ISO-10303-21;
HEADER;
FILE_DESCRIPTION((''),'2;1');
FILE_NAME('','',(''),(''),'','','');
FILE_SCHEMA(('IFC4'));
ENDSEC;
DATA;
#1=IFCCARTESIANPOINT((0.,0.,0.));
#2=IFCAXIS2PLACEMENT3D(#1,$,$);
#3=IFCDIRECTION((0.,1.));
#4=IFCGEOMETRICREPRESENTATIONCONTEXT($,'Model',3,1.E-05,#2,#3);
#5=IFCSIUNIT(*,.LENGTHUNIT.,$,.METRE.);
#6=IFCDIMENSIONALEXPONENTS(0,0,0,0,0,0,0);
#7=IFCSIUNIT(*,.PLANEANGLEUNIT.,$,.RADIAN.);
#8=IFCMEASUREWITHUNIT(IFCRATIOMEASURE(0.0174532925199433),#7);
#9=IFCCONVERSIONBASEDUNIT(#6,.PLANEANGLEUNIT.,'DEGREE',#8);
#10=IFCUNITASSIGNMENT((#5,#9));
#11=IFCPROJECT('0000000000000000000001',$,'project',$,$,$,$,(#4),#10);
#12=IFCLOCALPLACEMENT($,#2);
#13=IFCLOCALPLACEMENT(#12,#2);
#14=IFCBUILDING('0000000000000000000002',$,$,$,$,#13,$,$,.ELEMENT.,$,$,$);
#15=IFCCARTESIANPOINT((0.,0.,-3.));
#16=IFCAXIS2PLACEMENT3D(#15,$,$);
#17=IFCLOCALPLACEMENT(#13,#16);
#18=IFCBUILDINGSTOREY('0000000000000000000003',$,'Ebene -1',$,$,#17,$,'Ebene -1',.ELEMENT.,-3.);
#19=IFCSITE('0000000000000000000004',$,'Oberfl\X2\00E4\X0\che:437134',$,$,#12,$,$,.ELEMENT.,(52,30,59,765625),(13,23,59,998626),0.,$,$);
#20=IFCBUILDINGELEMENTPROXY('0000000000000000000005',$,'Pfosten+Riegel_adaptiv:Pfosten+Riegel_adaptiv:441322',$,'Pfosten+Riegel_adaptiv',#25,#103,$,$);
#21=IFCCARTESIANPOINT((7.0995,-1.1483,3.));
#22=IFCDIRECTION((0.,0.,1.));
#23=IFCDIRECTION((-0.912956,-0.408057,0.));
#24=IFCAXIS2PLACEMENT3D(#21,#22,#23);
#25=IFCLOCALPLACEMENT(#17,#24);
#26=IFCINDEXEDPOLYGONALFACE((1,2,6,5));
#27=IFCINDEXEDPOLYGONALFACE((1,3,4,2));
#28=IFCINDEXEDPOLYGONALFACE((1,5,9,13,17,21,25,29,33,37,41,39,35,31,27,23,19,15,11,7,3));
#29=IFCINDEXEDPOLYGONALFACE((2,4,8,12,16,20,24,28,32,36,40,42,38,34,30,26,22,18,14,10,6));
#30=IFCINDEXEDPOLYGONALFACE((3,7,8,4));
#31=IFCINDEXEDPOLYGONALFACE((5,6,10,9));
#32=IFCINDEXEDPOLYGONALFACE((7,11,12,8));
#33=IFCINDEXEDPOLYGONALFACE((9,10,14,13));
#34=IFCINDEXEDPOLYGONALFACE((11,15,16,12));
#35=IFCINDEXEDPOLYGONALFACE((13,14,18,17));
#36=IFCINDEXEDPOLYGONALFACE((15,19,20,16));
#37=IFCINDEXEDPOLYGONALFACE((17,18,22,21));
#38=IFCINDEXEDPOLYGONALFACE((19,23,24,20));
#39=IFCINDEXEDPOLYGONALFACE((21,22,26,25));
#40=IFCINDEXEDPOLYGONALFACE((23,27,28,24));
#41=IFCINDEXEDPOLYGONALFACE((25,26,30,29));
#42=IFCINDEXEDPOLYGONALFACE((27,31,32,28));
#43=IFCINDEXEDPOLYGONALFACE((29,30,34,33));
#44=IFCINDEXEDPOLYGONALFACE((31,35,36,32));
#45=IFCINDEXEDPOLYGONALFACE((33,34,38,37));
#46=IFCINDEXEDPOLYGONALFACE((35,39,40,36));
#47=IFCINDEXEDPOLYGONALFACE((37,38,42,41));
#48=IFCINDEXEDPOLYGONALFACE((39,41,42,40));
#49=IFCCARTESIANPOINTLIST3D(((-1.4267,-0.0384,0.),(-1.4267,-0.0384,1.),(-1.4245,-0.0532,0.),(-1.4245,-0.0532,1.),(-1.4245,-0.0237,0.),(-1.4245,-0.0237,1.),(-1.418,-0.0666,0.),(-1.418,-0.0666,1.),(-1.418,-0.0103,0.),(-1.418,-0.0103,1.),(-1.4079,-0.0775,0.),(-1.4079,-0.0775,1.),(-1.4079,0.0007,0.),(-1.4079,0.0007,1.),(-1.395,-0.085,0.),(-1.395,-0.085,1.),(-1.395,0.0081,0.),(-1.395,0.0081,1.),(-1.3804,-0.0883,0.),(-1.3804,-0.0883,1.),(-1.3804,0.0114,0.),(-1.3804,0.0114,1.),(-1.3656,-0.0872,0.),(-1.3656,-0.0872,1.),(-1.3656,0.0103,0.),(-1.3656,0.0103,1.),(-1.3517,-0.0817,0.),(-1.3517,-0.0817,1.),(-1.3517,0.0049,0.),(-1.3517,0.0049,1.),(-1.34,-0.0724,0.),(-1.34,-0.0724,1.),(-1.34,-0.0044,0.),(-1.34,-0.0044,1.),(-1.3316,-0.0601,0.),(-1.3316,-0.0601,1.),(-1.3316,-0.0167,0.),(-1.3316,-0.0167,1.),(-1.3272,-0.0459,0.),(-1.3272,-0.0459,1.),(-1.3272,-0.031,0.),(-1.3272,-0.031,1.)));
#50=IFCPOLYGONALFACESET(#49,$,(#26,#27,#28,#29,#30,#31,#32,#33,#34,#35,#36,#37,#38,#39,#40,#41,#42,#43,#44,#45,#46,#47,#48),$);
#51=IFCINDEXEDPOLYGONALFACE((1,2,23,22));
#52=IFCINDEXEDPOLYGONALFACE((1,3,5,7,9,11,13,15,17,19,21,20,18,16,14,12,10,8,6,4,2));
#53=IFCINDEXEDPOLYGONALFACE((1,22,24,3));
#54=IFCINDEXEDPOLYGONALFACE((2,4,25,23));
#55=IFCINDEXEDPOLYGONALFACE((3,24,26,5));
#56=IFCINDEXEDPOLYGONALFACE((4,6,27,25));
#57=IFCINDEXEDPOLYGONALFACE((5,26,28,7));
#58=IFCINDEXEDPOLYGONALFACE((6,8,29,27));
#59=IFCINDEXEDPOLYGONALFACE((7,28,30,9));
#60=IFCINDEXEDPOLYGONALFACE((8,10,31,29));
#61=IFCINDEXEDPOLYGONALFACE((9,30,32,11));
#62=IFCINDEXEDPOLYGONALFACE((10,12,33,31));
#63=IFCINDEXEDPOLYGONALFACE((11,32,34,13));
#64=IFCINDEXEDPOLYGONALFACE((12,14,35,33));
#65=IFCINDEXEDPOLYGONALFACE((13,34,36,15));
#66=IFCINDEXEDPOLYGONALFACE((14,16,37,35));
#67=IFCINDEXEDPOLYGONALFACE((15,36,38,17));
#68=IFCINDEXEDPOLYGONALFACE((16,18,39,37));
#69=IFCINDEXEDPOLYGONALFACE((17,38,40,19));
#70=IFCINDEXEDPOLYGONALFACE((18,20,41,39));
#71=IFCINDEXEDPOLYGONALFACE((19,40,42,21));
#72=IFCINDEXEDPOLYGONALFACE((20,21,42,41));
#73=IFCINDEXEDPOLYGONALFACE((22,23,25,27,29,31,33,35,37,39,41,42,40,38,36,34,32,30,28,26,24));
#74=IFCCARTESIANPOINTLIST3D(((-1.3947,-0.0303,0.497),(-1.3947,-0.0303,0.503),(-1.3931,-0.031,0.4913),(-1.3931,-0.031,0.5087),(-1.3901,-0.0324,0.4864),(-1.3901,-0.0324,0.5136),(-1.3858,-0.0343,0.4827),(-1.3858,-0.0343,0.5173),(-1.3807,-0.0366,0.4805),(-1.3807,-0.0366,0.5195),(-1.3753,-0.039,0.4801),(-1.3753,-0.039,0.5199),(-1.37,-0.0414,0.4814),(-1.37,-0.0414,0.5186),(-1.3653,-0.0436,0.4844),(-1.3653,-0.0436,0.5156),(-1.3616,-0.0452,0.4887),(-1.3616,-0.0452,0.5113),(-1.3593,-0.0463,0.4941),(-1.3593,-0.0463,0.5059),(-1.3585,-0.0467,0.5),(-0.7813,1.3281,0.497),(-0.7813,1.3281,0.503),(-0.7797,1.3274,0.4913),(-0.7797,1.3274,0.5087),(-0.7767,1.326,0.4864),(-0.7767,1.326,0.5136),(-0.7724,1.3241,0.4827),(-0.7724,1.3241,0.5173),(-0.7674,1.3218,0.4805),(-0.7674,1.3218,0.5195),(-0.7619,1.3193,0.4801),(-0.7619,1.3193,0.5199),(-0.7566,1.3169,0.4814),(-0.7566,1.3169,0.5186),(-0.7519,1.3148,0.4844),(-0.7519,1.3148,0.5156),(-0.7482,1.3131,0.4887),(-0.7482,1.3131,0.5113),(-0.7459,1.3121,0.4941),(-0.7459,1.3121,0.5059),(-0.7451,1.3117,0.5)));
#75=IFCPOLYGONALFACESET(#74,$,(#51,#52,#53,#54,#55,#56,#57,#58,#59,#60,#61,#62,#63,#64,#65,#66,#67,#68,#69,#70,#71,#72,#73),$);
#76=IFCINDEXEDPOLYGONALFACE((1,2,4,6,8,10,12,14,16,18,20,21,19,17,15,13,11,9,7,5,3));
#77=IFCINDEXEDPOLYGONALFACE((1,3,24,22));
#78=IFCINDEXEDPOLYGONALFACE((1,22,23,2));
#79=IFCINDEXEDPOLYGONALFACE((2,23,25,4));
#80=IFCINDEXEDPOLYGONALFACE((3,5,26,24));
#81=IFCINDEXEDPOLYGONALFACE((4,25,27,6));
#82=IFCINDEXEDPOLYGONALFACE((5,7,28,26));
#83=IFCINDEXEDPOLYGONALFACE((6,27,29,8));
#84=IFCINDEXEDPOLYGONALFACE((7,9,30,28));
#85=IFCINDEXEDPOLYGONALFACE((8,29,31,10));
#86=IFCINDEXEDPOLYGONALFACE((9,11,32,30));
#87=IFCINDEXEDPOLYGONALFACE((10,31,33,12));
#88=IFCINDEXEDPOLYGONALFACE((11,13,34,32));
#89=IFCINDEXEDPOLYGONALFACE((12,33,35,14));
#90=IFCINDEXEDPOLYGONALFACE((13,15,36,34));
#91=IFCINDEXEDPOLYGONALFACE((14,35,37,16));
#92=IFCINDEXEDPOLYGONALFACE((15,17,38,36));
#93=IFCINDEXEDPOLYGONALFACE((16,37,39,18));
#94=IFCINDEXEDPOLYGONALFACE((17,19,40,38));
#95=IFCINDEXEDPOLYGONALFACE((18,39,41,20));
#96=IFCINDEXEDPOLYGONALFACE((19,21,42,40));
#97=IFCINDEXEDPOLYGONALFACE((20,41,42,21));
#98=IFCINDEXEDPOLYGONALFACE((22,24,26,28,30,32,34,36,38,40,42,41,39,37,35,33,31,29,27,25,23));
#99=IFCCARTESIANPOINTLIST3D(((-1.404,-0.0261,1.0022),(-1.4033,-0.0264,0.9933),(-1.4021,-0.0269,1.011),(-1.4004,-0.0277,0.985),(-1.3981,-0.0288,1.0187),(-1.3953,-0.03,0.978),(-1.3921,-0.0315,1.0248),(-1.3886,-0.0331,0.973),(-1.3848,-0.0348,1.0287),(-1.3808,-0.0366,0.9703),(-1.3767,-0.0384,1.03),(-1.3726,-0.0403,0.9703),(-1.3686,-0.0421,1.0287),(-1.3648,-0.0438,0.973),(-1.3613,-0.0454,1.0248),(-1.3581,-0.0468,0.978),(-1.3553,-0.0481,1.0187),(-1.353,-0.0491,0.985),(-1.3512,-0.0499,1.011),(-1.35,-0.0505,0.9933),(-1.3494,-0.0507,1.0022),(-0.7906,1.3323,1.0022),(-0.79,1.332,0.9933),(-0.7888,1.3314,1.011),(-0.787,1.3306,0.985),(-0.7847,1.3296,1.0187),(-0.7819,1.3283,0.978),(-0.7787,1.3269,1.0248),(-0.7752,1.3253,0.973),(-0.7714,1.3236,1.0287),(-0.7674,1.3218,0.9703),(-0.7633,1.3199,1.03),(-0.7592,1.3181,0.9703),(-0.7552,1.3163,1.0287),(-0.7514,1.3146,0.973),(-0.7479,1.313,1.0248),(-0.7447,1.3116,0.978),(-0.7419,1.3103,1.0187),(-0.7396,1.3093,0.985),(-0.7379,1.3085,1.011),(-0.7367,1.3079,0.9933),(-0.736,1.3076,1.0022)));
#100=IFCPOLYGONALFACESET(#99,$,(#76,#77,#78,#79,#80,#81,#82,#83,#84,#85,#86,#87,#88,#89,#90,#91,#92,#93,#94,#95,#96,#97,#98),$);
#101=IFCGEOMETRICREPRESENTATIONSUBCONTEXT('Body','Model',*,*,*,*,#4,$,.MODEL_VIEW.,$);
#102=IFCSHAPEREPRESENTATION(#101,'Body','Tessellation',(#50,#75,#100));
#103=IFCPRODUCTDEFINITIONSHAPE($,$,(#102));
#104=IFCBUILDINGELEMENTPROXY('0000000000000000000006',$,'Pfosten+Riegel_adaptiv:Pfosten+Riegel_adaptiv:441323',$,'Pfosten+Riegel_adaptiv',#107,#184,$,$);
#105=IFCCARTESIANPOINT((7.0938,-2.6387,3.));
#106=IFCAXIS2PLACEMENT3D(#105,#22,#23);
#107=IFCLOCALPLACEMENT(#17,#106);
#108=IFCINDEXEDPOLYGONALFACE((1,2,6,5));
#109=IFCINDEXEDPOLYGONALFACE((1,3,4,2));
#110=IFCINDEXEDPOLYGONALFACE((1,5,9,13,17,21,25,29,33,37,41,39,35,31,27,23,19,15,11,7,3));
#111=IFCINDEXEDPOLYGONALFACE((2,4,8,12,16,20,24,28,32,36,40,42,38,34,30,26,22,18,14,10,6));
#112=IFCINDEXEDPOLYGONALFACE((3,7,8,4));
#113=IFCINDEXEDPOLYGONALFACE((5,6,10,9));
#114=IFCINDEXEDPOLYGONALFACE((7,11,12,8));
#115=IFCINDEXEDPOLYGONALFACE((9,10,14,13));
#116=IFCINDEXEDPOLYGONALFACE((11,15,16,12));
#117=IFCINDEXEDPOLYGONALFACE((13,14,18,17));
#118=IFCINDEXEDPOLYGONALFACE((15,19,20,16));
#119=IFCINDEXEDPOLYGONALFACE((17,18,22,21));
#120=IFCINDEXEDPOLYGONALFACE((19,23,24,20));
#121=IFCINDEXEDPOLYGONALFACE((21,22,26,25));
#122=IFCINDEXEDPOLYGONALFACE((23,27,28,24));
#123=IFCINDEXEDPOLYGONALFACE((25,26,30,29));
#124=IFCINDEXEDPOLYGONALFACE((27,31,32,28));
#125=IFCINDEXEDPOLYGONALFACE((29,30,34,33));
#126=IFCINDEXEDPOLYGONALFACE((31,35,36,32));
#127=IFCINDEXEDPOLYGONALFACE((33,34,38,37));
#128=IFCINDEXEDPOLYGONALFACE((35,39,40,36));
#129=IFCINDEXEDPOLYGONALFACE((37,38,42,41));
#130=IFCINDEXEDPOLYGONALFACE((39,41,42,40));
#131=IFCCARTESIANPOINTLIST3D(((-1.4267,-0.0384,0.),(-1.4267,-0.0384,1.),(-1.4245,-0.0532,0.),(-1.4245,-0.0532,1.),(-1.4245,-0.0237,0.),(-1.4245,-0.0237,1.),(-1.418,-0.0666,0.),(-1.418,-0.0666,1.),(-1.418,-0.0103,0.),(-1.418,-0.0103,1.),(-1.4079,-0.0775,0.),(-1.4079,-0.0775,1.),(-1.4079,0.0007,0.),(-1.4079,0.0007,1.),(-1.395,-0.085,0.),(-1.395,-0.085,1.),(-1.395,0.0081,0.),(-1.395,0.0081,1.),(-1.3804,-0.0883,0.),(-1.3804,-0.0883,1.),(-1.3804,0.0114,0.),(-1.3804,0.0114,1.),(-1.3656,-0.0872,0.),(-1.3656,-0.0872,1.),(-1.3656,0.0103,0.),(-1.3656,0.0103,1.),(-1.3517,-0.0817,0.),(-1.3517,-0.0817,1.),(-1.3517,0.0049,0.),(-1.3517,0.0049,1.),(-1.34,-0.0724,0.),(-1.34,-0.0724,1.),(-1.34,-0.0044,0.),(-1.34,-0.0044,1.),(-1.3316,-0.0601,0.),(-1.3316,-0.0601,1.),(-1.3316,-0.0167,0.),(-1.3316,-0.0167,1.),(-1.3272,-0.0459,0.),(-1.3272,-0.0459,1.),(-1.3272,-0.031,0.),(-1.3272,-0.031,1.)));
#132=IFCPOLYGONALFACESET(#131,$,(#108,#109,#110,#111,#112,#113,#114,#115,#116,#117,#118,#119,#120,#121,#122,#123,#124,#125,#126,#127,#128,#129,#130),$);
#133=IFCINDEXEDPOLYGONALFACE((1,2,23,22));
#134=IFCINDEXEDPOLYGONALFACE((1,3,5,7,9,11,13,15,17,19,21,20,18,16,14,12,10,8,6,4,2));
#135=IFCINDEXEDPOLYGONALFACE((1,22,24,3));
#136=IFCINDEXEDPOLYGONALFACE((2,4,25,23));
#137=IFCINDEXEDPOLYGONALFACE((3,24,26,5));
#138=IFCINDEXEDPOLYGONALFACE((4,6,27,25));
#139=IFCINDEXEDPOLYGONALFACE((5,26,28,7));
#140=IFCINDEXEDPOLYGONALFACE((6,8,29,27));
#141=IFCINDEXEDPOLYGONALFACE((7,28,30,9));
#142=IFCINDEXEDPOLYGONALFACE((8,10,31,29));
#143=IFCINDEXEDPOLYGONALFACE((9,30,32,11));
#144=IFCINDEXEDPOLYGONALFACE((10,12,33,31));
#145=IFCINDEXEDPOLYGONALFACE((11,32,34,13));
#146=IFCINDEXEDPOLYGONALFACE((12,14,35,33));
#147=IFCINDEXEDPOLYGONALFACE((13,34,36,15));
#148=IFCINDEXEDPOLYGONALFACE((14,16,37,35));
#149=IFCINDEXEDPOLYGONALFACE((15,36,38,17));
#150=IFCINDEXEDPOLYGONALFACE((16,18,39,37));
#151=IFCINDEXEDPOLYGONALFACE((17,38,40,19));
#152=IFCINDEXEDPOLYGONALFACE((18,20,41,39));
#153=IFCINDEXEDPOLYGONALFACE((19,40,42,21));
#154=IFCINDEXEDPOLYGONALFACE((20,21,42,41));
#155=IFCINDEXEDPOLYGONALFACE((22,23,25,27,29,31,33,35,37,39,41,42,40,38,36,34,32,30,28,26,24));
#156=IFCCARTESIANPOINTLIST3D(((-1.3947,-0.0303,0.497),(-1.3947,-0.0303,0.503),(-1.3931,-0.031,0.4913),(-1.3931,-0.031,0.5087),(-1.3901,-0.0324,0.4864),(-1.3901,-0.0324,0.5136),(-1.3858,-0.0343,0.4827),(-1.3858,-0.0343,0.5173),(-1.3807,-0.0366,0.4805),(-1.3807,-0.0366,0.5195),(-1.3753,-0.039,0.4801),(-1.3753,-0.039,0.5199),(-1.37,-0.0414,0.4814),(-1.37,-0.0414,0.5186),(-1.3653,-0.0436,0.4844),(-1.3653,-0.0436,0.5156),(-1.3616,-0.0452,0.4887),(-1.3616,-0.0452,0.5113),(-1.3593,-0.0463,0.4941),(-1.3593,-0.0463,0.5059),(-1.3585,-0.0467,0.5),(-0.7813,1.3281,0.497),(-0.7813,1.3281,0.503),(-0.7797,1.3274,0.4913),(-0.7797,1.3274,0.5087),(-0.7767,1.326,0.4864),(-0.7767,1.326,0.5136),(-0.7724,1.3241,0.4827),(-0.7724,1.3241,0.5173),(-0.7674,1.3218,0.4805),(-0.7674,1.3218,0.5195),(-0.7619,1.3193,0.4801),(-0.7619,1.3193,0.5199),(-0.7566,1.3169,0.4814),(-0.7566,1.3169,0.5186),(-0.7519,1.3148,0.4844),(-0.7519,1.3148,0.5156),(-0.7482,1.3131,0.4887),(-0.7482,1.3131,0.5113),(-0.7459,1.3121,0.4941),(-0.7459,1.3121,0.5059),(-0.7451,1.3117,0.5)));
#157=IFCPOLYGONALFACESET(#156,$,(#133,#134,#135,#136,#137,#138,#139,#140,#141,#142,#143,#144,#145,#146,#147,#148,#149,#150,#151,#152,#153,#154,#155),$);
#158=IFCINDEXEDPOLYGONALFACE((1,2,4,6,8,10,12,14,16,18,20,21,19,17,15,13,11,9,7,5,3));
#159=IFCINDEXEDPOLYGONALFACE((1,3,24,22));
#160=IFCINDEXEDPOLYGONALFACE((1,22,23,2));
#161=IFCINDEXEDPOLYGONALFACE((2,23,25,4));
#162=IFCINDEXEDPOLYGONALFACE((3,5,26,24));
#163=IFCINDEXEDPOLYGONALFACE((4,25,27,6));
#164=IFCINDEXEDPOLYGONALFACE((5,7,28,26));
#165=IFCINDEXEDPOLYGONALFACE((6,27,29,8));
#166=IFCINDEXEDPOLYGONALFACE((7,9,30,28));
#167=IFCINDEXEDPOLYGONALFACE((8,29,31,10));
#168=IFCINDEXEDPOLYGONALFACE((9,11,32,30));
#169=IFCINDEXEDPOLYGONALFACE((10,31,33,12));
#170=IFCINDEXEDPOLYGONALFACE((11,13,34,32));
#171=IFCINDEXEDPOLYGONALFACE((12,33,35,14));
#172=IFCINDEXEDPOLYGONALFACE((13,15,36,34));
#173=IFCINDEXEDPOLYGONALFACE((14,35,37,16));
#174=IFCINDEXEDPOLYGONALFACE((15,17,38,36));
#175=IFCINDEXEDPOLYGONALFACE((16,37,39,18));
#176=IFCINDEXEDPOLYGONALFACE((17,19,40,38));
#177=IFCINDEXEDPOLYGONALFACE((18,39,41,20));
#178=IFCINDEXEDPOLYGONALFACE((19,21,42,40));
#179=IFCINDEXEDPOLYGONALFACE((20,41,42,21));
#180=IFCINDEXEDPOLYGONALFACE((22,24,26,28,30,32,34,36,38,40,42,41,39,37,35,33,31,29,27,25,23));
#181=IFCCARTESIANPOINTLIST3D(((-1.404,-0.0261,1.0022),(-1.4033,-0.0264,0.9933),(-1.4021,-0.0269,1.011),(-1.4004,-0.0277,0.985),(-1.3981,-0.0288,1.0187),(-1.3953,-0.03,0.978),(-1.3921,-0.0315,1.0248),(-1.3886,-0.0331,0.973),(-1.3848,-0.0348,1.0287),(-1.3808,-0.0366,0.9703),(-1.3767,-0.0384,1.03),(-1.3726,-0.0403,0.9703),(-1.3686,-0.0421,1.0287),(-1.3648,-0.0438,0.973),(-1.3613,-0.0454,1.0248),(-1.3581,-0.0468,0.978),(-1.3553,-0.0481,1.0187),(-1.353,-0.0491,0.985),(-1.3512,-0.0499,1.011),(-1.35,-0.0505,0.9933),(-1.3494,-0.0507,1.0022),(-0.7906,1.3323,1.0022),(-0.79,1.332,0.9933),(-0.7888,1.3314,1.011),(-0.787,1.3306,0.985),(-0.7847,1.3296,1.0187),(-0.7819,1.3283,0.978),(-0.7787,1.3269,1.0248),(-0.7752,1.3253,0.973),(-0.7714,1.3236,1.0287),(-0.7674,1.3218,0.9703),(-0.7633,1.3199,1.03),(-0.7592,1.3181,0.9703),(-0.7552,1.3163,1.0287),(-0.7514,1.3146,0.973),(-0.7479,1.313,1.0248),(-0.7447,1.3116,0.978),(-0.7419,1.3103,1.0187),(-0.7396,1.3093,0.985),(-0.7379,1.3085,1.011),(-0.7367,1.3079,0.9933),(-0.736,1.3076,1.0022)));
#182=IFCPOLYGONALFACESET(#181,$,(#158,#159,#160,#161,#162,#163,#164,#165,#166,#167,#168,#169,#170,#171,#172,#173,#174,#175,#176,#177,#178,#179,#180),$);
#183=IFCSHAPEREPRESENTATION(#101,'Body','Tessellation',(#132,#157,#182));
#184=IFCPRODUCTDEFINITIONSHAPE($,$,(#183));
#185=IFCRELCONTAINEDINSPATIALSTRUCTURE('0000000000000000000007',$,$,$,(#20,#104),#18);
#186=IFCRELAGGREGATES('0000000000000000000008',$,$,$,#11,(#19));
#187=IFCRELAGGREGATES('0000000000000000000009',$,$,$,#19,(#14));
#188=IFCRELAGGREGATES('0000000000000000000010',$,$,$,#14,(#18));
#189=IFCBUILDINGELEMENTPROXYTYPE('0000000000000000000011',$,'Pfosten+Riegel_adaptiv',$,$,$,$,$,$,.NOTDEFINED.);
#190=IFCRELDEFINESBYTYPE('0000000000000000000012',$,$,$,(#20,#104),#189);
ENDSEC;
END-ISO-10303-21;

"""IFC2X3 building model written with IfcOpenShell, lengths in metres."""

from ifc_helpers import new_model, entity, si_unit, converted_unit, direction, frame, frame_2d, origin, place, context, subcontext, project, spatial, circle, extrude, source, transform, mapped, type_object, type_shapes, element, save


model = new_model("IFC2X3")

# Units and contexts
model_context = context("Model", 3, precision=1e-05, world=origin(), true_north=direction((0.0, 1.0)))
body_context = subcontext(model_context, "Body", "Model", "MODEL_VIEW")
ifc_project = project(units=[si_unit("LENGTHUNIT", "METRE"), converted_unit("PLANEANGLEUNIT", "DEGREE", entity("IfcRatioMeasure", 0.0174532925199433), si_unit("PLANEANGLEUNIT", "RADIAN"), dimensions=[0, 0, 0, 0, 0, 0, 0])], contexts=[model_context])

# Site, building, storey
site_placement = place(None, origin())
site = spatial("IfcSite", under=ifc_project, at=site_placement, Name="Oberfläche:437134", CompositionType="ELEMENT", RefLatitude=(52, 30, 59, 765625), RefLongitude=(13, 23, 59, 998626), RefElevation=0.0)
building_placement = place(site_placement, origin())
building = spatial("IfcBuilding", under=site, at=building_placement, CompositionType="ELEMENT")
storey_placement = place(building_placement, frame((0.0, 0.0, -3.0)))
storey = spatial("IfcBuildingStorey", under=building, at=storey_placement, Name="Ebene -1", LongName="Ebene -1", CompositionType="ELEMENT", Elevation=-3.0)

# Building element proxies
building_element_proxy_type_1 = type_object("IfcBuildingElementProxyType", Name="Pfosten+Riegel_adaptiv", PredefinedType="NOTDEFINED")
shared_shape_1 = source(origin(), body_context, "Body", "SweptSolid", [
    extrude(circle(Radius=0.05, at=frame_2d((0.0, 0.0), x_axis=(1.0, 0.0))), frame((-1.3767, -0.0384, 0.0), z_axis=(0.0, 0.0, 1.0), x_axis=(-1.0, 0.0, 0.0)), (0.0, 0.0, 1.0), 1.0),
    extrude(circle(Radius=0.02, at=frame_2d((0.0, 0.0), x_axis=(1.0, 0.0))), frame((-1.3767, -0.0384, 0.5), z_axis=(0.411546, 0.911389, 0.0), x_axis=(0.911389, -0.411546, 0.0)), (0.0, 0.0, 1.0), 1.4904),
    extrude(circle(Radius=0.03, at=frame_2d((0.0, 0.0), x_axis=(1.0, 0.0))), frame((-1.3767, -0.0384, 1.0), z_axis=(0.411546, 0.911389, 0.0), x_axis=(0.0, 0.0, 1.0)), (0.0, 0.0, 1.0), 1.4904),
])
type_shapes(building_element_proxy_type_1, [shared_shape_1])
for number, where, z_axis, x_axis, name in (
    (1, (7.0995, -1.1483, 3.0), (0.0, 0.0, 1.0), (-0.912956, -0.408057, 0.0), "Pfosten+Riegel_adaptiv:Pfosten+Riegel_adaptiv:441322"),
    (2, (7.0938, -2.6387, 3.0), (0.0, 0.0, 1.0), (-0.912956, -0.408057, 0.0), "Pfosten+Riegel_adaptiv:Pfosten+Riegel_adaptiv:441323"),
):
    element("IfcBuildingElementProxy", number, at=place(storey_placement, frame(where, z_axis=z_axis, x_axis=x_axis)), inside=storey, type_object=building_element_proxy_type_1, Name=name, ObjectType="Pfosten+Riegel_adaptiv", context=body_context, shape_type="MappedRepresentation", body=[
        mapped(shared_shape_1, transform((0.0, 0.0, 0.0), scale=1.0)),
    ])

save(model, "model.ifc")
